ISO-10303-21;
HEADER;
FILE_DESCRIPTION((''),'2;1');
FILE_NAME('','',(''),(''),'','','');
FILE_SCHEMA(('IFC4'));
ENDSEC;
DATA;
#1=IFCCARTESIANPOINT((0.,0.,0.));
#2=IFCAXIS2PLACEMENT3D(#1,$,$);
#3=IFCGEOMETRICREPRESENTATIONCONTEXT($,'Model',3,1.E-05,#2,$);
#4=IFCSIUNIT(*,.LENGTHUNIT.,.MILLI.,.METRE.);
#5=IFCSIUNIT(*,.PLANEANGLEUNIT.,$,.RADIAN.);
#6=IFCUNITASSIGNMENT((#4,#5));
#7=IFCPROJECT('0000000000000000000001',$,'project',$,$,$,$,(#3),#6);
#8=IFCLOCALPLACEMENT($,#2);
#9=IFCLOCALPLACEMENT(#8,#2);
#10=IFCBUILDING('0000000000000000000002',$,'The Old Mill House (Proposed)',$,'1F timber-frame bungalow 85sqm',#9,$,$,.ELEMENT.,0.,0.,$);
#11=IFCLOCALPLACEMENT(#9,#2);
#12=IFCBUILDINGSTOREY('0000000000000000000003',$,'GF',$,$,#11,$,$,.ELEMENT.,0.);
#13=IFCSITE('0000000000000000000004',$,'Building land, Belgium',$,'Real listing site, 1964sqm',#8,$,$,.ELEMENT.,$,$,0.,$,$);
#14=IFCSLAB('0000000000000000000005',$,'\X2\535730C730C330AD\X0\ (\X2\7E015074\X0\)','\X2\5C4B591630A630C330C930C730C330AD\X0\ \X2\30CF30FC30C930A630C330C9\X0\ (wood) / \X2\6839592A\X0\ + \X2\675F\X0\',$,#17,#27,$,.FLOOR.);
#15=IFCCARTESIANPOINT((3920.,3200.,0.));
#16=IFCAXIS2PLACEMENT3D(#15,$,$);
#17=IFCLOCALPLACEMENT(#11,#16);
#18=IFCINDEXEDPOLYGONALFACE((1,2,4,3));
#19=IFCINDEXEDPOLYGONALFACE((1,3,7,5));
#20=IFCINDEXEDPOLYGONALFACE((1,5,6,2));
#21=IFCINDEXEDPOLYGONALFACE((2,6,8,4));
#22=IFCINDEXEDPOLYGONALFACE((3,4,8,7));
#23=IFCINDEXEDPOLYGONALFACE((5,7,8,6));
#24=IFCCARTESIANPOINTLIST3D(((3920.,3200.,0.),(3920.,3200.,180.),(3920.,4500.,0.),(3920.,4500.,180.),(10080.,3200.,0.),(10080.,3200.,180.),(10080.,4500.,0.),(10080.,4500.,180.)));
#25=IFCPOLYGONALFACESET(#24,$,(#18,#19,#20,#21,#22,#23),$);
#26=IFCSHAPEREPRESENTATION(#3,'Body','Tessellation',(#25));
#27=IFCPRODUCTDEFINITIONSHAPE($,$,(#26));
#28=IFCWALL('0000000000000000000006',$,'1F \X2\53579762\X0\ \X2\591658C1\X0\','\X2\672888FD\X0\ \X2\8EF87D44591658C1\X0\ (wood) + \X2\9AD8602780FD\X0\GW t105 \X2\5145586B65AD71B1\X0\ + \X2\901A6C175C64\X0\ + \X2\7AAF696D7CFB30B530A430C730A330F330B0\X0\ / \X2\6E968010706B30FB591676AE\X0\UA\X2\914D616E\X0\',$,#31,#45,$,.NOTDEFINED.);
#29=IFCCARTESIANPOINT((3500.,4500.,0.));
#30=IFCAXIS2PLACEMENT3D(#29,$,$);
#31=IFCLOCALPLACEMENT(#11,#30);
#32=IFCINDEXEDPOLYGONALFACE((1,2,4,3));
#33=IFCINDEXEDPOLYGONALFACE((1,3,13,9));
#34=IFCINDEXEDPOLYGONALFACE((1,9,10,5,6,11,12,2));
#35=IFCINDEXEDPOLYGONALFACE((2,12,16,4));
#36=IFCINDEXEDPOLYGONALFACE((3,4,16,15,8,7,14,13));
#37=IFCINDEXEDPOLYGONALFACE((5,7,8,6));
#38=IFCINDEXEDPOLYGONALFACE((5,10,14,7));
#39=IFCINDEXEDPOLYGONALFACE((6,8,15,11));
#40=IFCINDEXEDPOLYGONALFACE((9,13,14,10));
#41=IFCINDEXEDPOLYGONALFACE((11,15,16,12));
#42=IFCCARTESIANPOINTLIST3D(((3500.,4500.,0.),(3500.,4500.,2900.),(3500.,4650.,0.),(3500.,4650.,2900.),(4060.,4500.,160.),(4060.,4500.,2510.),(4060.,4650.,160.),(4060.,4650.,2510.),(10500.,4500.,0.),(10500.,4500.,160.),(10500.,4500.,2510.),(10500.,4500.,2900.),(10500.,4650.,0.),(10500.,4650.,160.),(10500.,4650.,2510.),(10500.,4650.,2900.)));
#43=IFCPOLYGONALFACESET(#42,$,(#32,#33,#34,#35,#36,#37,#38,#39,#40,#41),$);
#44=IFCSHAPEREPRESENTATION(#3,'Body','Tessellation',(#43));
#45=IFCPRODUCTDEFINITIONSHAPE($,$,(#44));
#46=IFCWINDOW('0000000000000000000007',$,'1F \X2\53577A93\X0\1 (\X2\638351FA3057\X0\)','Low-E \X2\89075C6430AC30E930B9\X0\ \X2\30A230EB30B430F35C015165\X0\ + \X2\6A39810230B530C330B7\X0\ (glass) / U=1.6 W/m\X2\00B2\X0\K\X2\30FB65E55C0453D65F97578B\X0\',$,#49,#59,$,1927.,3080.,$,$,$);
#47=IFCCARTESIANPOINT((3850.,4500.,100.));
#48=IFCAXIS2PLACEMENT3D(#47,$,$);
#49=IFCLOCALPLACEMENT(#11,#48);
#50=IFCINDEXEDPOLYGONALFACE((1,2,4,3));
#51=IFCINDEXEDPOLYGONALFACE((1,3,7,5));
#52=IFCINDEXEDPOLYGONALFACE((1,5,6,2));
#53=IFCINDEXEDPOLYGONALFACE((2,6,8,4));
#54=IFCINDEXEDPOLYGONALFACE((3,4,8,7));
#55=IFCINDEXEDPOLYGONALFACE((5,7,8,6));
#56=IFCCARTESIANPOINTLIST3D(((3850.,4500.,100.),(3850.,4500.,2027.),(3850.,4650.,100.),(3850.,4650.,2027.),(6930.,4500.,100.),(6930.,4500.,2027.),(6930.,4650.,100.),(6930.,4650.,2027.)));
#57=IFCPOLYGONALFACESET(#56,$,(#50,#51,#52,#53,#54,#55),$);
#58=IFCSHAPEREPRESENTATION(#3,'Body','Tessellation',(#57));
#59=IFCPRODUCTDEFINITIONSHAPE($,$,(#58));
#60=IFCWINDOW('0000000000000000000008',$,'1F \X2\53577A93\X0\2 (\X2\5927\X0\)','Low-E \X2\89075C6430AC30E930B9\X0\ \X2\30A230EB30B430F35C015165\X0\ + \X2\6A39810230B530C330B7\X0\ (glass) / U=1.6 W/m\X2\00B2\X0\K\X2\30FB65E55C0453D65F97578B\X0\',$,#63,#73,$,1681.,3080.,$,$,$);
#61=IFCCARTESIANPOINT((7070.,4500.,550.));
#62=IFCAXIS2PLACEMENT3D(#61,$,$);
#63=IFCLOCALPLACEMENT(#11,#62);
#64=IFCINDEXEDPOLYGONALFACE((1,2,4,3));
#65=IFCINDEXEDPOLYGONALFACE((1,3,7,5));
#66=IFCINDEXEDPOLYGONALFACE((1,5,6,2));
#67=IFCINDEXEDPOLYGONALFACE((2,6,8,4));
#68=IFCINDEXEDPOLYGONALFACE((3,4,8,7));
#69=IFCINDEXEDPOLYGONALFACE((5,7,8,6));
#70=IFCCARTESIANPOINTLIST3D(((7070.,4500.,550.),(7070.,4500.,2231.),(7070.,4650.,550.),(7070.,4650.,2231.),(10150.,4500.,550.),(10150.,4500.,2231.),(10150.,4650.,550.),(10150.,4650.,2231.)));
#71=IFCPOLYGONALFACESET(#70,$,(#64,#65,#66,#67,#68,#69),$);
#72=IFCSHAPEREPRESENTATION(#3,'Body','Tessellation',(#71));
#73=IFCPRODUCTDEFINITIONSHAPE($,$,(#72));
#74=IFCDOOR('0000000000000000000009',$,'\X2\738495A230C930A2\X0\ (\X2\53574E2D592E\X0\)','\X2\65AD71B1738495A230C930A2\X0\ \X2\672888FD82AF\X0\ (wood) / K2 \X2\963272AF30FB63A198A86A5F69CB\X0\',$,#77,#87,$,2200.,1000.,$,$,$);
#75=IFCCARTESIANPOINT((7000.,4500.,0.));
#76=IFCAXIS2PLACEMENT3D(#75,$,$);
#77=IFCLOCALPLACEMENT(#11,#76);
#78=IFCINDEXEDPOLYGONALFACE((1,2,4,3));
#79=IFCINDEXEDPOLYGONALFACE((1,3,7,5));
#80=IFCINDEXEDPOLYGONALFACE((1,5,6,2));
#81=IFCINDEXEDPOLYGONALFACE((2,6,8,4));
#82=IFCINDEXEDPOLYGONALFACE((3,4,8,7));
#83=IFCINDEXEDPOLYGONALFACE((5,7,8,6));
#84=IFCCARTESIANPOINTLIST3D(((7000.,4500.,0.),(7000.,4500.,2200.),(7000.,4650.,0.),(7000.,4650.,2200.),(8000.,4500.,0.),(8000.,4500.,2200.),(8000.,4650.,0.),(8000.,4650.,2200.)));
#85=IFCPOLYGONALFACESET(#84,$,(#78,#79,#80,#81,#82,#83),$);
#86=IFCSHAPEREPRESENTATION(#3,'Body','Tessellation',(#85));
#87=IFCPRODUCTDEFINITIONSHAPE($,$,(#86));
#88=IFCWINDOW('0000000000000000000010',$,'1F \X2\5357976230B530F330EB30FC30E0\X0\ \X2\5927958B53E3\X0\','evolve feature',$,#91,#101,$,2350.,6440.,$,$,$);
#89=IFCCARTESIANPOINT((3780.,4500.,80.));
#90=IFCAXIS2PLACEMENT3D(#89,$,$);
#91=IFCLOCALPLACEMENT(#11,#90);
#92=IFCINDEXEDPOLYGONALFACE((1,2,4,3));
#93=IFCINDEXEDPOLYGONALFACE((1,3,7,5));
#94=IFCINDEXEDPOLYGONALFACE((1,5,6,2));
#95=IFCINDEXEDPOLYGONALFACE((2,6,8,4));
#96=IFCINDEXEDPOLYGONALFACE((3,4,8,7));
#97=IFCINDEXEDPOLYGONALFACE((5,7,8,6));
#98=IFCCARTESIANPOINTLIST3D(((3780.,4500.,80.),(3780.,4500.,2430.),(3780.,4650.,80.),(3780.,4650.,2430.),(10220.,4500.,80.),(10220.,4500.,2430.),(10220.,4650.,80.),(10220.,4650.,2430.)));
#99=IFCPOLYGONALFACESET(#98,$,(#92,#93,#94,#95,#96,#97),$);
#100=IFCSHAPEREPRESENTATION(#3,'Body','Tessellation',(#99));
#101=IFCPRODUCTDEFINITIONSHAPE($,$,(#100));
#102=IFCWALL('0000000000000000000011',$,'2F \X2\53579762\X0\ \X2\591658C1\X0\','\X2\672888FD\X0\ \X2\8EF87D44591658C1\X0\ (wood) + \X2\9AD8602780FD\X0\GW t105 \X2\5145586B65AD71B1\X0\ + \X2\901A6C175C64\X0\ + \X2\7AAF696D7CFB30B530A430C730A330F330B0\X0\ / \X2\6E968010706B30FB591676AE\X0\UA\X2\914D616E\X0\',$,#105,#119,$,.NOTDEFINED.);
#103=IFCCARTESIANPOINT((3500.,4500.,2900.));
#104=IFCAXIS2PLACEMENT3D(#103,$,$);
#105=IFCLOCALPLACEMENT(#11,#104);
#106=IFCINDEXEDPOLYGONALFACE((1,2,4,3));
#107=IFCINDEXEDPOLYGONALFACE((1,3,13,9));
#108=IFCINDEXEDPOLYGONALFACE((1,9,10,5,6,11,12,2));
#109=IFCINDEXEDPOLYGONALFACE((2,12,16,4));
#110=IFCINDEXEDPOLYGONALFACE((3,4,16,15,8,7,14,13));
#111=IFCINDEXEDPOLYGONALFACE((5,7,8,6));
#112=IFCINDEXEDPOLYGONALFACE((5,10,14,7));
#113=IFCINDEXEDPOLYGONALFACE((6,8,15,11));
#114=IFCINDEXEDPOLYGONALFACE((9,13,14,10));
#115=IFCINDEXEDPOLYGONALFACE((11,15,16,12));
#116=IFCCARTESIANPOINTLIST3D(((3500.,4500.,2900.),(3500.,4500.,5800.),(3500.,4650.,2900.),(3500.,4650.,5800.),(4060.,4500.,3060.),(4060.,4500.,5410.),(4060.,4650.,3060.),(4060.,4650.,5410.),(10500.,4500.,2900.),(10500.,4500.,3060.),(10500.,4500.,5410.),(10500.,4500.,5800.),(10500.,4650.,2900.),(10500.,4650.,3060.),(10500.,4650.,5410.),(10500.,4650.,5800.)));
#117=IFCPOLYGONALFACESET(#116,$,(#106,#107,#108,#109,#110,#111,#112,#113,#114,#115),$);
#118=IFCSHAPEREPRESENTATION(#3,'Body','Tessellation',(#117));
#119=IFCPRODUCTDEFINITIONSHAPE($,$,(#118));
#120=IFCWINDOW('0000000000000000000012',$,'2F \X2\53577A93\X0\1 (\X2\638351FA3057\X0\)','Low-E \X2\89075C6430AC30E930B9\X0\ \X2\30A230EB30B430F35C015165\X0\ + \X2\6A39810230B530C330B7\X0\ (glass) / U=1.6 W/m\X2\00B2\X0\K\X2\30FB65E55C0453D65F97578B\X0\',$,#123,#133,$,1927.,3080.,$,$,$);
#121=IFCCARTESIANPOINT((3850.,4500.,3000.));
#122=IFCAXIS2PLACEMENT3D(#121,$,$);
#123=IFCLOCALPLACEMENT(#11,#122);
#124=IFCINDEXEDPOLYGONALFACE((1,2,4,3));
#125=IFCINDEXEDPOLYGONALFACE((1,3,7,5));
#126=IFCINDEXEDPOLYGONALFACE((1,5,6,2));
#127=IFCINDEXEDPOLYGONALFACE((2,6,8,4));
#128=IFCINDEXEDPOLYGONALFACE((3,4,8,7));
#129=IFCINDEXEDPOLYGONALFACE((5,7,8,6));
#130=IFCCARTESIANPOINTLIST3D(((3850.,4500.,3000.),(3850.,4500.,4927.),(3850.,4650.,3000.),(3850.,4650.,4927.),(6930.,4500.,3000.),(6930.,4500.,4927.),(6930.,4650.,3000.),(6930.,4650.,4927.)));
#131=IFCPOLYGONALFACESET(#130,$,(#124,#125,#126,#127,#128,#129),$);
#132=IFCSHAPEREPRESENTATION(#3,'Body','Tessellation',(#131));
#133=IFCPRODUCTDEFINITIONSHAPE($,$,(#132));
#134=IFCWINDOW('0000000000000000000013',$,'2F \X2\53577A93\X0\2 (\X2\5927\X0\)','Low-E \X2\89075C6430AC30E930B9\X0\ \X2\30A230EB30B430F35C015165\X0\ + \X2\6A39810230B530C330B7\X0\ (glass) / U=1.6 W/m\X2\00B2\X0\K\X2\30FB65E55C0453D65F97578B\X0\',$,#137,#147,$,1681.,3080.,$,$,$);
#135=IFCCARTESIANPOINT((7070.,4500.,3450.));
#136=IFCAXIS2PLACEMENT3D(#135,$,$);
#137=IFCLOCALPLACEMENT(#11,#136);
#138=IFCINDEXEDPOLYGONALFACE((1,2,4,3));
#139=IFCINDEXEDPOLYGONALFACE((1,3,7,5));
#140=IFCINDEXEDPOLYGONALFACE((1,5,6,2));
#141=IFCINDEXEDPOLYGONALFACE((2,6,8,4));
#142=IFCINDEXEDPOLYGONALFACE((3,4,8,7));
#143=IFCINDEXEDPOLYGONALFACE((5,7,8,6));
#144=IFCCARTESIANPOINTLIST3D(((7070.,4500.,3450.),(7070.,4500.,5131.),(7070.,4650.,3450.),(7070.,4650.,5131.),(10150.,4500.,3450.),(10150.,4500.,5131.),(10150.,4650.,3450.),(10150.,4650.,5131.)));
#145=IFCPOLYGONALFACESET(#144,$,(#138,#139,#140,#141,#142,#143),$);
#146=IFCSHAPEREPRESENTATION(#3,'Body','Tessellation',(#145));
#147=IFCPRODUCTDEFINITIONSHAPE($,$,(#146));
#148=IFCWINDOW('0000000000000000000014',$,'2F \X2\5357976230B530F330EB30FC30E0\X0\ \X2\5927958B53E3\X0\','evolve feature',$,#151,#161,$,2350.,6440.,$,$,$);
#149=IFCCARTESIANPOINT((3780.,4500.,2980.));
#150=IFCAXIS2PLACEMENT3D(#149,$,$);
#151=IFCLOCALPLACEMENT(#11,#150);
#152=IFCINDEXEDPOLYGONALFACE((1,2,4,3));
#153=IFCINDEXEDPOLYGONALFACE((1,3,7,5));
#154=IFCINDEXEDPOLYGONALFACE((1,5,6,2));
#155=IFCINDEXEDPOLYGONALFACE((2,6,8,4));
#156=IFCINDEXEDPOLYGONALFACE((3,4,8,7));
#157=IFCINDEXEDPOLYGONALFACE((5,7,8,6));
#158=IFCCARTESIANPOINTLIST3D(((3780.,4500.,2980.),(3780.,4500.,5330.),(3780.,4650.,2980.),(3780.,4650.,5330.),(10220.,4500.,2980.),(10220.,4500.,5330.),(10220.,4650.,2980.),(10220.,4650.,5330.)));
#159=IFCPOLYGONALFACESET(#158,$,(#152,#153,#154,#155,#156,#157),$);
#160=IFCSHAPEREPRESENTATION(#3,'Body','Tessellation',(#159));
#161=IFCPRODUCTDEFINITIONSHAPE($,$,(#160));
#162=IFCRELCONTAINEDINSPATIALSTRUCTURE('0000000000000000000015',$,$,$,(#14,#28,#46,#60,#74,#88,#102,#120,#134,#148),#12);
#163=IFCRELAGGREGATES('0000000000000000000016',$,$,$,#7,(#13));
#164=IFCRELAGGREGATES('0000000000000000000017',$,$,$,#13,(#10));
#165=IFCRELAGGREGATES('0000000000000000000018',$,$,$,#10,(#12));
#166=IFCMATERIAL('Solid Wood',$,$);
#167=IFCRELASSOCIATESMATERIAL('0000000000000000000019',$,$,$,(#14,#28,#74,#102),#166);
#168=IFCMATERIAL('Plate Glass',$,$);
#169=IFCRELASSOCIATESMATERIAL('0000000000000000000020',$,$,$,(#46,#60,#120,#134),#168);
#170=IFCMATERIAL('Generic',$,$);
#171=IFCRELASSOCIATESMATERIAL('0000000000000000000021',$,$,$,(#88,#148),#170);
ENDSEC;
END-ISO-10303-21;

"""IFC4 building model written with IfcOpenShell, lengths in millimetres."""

from ifc_helpers import new_model, si_unit, frame, frame_2d, origin, place, context, project, spatial, rectangle, extrude, material, element, fill, save


model = new_model("IFC4")

# Units and contexts
model_context = context("Model", 3, precision=1e-05, world=origin())
ifc_project = project(units=[si_unit("LENGTHUNIT", "METRE", prefix="MILLI"), si_unit("PLANEANGLEUNIT", "RADIAN")], contexts=[model_context])

# Site, building, storey
site_placement = place(None, origin())
site = spatial("IfcSite", under=ifc_project, at=site_placement, Name="Building land, Belgium", ObjectType="Real listing site, 1964sqm", CompositionType="ELEMENT", RefElevation=0.0)
building_placement = place(site_placement, origin())
building = spatial("IfcBuilding", under=site, at=building_placement, Name="The Old Mill House (Proposed)", ObjectType="1F timber-frame bungalow 85sqm", CompositionType="ELEMENT", ElevationOfRefHeight=0.0, ElevationOfTerrain=0.0)
storey_placement = place(building_placement, origin())
storey = spatial("IfcBuildingStorey", under=building, at=storey_placement, Name="GF", CompositionType="ELEMENT", Elevation=0.0)

# Slab
ifc_material_1 = material(Name="Solid Wood")
slab_1_placement = place(storey_placement, frame((3920.0, 3200.0, 0.0)))
element("IfcSlab", 1, at=slab_1_placement, inside=storey, material=ifc_material_1, Name="南デッキ (縁側)", Description="屋外ウッドデッキ ハードウッド (wood) / 根太 + 束", PredefinedType="FLOOR", context=model_context, shape_type="SweptSolid", body=[
    extrude(rectangle(XDim=6160.0, YDim=1300.0, at=frame_2d((3080.0, 650.0))), frame((3920.0, 3200.0, 0.0)), (0.0, 0.0, 1.0), 180.0),
])
ifc_material_2 = material(Name="Generic")

# Wall, openings, windows, door
wall_1_placement = place(storey_placement, frame((3500.0, 4500.0, 0.0)))
wall_1 = element("IfcWall", 2, at=wall_1_placement, inside=storey, material=ifc_material_1, Name="1F 南面 外壁", Description="木製 軸組外壁 (wood) + 高性能GW t105 充填断熱 + 通気層 + 窯業系サイディング / 準耐火・外皮UA配慮", PredefinedType="NOTDEFINED", context=model_context, shape_type="SweptSolid", body=[
    extrude(rectangle(XDim=7000.0, YDim=150.0, at=frame_2d((3500.0, 75.0))), frame((3500.0, 4500.0, 0.0)), (0.0, 0.0, 1.0), 2900.0),
])
opening_1_placement = place(storey_placement, frame((3850.0, 4500.0, 100.0)))
opening_1 = element("IfcOpeningElement", 3, at=opening_1_placement, cuts=wall_1, PredefinedType="NOTDEFINED", context=model_context, shape_type="SweptSolid", body=[
    extrude(rectangle(XDim=3080.0, YDim=150.0, at=frame_2d((1540.0, 75.0))), frame((3850.0, 4500.0, 100.0)), (0.0, 0.0, 1.0), 1927.0),
])
opening_2_placement = place(storey_placement, frame((7070.0, 4500.0, 550.0)))
opening_2 = element("IfcOpeningElement", 4, at=opening_2_placement, cuts=wall_1, PredefinedType="NOTDEFINED", context=model_context, shape_type="SweptSolid", body=[
    extrude(rectangle(XDim=3080.0, YDim=150.0, at=frame_2d((1540.0, 75.0))), frame((7070.0, 4500.0, 550.0)), (0.0, 0.0, 1.0), 1681.0),
])
opening_3_placement = place(storey_placement, frame((7000.0, 4500.0, 0.0)))
opening_3 = element("IfcOpeningElement", 5, at=opening_3_placement, cuts=wall_1, PredefinedType="NOTDEFINED", context=model_context, shape_type="SweptSolid", body=[
    extrude(rectangle(XDim=1000.0, YDim=150.0, at=frame_2d((500.0, 75.0))), frame((7000.0, 4500.0, 0.0)), (0.0, 0.0, 1.0), 2200.0),
])
opening_4_placement = place(storey_placement, frame((3780.0, 4500.0, 80.0)))
opening_4 = element("IfcOpeningElement", 6, at=opening_4_placement, cuts=wall_1, PredefinedType="NOTDEFINED", context=model_context, shape_type="SweptSolid", body=[
    extrude(rectangle(XDim=6440.0, YDim=150.0, at=frame_2d((3220.0, 75.0))), frame((3780.0, 4500.0, 80.0)), (0.0, 0.0, 1.0), 2350.0),
])
ifc_material_3 = material(Name="Plate Glass")
window_1_placement = place(storey_placement, frame((3850.0, 4500.0, 100.0)))
window_1 = element("IfcWindow", 7, at=window_1_placement, inside=storey, material=ifc_material_3, Name="1F 南窓1 (掃出し)", Description="Low-E 複層ガラス アルゴン封入 + 樹脂サッシ (glass) / U=1.6 W/m²K・日射取得型", OverallHeight=1927.0, OverallWidth=3080.0, context=model_context, shape_type="SweptSolid", body=[
    extrude(rectangle(XDim=3080.0, YDim=150.0, at=frame_2d((1540.0, 75.0))), frame((3850.0, 4500.0, 100.0)), (0.0, 0.0, 1.0), 1927.0),
])
fill(opening_1, window_1)
window_2_placement = place(storey_placement, frame((7070.0, 4500.0, 550.0)))
window_2 = element("IfcWindow", 8, at=window_2_placement, inside=storey, material=ifc_material_3, Name="1F 南窓2 (大)", Description="Low-E 複層ガラス アルゴン封入 + 樹脂サッシ (glass) / U=1.6 W/m²K・日射取得型", OverallHeight=1681.0, OverallWidth=3080.0, context=model_context, shape_type="SweptSolid", body=[
    extrude(rectangle(XDim=3080.0, YDim=150.0, at=frame_2d((1540.0, 75.0))), frame((7070.0, 4500.0, 550.0)), (0.0, 0.0, 1.0), 1681.0),
])
fill(opening_2, window_2)
door_placement = place(storey_placement, frame((7000.0, 4500.0, 0.0)))
door = element("IfcDoor", 9, at=door_placement, inside=storey, material=ifc_material_1, Name="玄関ドア (南中央)", Description="断熱玄関ドア 木製芯 (wood) / K2 防犯・採風機構", OverallHeight=2200.0, OverallWidth=1000.0, context=model_context, shape_type="SweptSolid", body=[
    extrude(rectangle(XDim=1000.0, YDim=150.0, at=frame_2d((500.0, 75.0))), frame((7000.0, 4500.0, 0.0)), (0.0, 0.0, 1.0), 2200.0),
])
fill(opening_3, door)
window_3_placement = place(storey_placement, frame((3780.0, 4500.0, 80.0)))
window_3 = element("IfcWindow", 10, at=window_3_placement, inside=storey, material=ifc_material_2, Name="1F 南面サンルーム 大開口", Description="evolve feature", OverallHeight=2350.0, OverallWidth=6440.0, context=model_context, shape_type="SweptSolid", body=[
    extrude(rectangle(XDim=6440.0, YDim=150.0, at=frame_2d((3220.0, 75.0))), frame((3780.0, 4500.0, 80.0)), (0.0, 0.0, 1.0), 2350.0),
])
fill(opening_4, window_3)

# Wall, openings, windows
wall_2_placement = place(storey_placement, frame((3500.0, 4500.0, 2900.0)))
wall_2 = element("IfcWall", 11, at=wall_2_placement, inside=storey, material=ifc_material_1, Name="2F 南面 外壁", Description="木製 軸組外壁 (wood) + 高性能GW t105 充填断熱 + 通気層 + 窯業系サイディング / 準耐火・外皮UA配慮", PredefinedType="NOTDEFINED", context=model_context, shape_type="SweptSolid", body=[
    extrude(rectangle(XDim=7000.0, YDim=150.0, at=frame_2d((3500.0, 75.0))), frame((3500.0, 4500.0, 2900.0)), (0.0, 0.0, 1.0), 2900.0),
])
opening_5_placement = place(storey_placement, frame((3850.0, 4500.0, 3000.0)))
opening_5 = element("IfcOpeningElement", 12, at=opening_5_placement, cuts=wall_2, PredefinedType="NOTDEFINED", context=model_context, shape_type="SweptSolid", body=[
    extrude(rectangle(XDim=3080.0, YDim=150.0, at=frame_2d((1540.0, 75.0))), frame((3850.0, 4500.0, 3000.0)), (0.0, 0.0, 1.0), 1927.0),
])
opening_6_placement = place(storey_placement, frame((7070.0, 4500.0, 3450.0)))
opening_6 = element("IfcOpeningElement", 13, at=opening_6_placement, cuts=wall_2, PredefinedType="NOTDEFINED", context=model_context, shape_type="SweptSolid", body=[
    extrude(rectangle(XDim=3080.0, YDim=150.0, at=frame_2d((1540.0, 75.0))), frame((7070.0, 4500.0, 3450.0)), (0.0, 0.0, 1.0), 1681.0),
])
opening_7_placement = place(storey_placement, frame((3780.0, 4500.0, 2980.0)))
opening_7 = element("IfcOpeningElement", 14, at=opening_7_placement, cuts=wall_2, PredefinedType="NOTDEFINED", context=model_context, shape_type="SweptSolid", body=[
    extrude(rectangle(XDim=6440.0, YDim=150.0, at=frame_2d((3220.0, 75.0))), frame((3780.0, 4500.0, 2980.0)), (0.0, 0.0, 1.0), 2350.0),
])
window_4_placement = place(storey_placement, frame((3850.0, 4500.0, 3000.0)))
window_4 = element("IfcWindow", 15, at=window_4_placement, inside=storey, material=ifc_material_3, Name="2F 南窓1 (掃出し)", Description="Low-E 複層ガラス アルゴン封入 + 樹脂サッシ (glass) / U=1.6 W/m²K・日射取得型", OverallHeight=1927.0, OverallWidth=3080.0, context=model_context, shape_type="SweptSolid", body=[
    extrude(rectangle(XDim=3080.0, YDim=150.0, at=frame_2d((1540.0, 75.0))), frame((3850.0, 4500.0, 3000.0)), (0.0, 0.0, 1.0), 1927.0),
])
fill(opening_5, window_4)
window_5_placement = place(storey_placement, frame((7070.0, 4500.0, 3450.0)))
window_5 = element("IfcWindow", 16, at=window_5_placement, inside=storey, material=ifc_material_3, Name="2F 南窓2 (大)", Description="Low-E 複層ガラス アルゴン封入 + 樹脂サッシ (glass) / U=1.6 W/m²K・日射取得型", OverallHeight=1681.0, OverallWidth=3080.0, context=model_context, shape_type="SweptSolid", body=[
    extrude(rectangle(XDim=3080.0, YDim=150.0, at=frame_2d((1540.0, 75.0))), frame((7070.0, 4500.0, 3450.0)), (0.0, 0.0, 1.0), 1681.0),
])
fill(opening_6, window_5)
window_6_placement = place(storey_placement, frame((3780.0, 4500.0, 2980.0)))
window_6 = element("IfcWindow", 17, at=window_6_placement, inside=storey, material=ifc_material_2, Name="2F 南面サンルーム 大開口", Description="evolve feature", OverallHeight=2350.0, OverallWidth=6440.0, context=model_context, shape_type="SweptSolid", body=[
    extrude(rectangle(XDim=6440.0, YDim=150.0, at=frame_2d((3220.0, 75.0))), frame((3780.0, 4500.0, 2980.0)), (0.0, 0.0, 1.0), 2350.0),
])
fill(opening_7, window_6)

save(model, "model.ifc")
